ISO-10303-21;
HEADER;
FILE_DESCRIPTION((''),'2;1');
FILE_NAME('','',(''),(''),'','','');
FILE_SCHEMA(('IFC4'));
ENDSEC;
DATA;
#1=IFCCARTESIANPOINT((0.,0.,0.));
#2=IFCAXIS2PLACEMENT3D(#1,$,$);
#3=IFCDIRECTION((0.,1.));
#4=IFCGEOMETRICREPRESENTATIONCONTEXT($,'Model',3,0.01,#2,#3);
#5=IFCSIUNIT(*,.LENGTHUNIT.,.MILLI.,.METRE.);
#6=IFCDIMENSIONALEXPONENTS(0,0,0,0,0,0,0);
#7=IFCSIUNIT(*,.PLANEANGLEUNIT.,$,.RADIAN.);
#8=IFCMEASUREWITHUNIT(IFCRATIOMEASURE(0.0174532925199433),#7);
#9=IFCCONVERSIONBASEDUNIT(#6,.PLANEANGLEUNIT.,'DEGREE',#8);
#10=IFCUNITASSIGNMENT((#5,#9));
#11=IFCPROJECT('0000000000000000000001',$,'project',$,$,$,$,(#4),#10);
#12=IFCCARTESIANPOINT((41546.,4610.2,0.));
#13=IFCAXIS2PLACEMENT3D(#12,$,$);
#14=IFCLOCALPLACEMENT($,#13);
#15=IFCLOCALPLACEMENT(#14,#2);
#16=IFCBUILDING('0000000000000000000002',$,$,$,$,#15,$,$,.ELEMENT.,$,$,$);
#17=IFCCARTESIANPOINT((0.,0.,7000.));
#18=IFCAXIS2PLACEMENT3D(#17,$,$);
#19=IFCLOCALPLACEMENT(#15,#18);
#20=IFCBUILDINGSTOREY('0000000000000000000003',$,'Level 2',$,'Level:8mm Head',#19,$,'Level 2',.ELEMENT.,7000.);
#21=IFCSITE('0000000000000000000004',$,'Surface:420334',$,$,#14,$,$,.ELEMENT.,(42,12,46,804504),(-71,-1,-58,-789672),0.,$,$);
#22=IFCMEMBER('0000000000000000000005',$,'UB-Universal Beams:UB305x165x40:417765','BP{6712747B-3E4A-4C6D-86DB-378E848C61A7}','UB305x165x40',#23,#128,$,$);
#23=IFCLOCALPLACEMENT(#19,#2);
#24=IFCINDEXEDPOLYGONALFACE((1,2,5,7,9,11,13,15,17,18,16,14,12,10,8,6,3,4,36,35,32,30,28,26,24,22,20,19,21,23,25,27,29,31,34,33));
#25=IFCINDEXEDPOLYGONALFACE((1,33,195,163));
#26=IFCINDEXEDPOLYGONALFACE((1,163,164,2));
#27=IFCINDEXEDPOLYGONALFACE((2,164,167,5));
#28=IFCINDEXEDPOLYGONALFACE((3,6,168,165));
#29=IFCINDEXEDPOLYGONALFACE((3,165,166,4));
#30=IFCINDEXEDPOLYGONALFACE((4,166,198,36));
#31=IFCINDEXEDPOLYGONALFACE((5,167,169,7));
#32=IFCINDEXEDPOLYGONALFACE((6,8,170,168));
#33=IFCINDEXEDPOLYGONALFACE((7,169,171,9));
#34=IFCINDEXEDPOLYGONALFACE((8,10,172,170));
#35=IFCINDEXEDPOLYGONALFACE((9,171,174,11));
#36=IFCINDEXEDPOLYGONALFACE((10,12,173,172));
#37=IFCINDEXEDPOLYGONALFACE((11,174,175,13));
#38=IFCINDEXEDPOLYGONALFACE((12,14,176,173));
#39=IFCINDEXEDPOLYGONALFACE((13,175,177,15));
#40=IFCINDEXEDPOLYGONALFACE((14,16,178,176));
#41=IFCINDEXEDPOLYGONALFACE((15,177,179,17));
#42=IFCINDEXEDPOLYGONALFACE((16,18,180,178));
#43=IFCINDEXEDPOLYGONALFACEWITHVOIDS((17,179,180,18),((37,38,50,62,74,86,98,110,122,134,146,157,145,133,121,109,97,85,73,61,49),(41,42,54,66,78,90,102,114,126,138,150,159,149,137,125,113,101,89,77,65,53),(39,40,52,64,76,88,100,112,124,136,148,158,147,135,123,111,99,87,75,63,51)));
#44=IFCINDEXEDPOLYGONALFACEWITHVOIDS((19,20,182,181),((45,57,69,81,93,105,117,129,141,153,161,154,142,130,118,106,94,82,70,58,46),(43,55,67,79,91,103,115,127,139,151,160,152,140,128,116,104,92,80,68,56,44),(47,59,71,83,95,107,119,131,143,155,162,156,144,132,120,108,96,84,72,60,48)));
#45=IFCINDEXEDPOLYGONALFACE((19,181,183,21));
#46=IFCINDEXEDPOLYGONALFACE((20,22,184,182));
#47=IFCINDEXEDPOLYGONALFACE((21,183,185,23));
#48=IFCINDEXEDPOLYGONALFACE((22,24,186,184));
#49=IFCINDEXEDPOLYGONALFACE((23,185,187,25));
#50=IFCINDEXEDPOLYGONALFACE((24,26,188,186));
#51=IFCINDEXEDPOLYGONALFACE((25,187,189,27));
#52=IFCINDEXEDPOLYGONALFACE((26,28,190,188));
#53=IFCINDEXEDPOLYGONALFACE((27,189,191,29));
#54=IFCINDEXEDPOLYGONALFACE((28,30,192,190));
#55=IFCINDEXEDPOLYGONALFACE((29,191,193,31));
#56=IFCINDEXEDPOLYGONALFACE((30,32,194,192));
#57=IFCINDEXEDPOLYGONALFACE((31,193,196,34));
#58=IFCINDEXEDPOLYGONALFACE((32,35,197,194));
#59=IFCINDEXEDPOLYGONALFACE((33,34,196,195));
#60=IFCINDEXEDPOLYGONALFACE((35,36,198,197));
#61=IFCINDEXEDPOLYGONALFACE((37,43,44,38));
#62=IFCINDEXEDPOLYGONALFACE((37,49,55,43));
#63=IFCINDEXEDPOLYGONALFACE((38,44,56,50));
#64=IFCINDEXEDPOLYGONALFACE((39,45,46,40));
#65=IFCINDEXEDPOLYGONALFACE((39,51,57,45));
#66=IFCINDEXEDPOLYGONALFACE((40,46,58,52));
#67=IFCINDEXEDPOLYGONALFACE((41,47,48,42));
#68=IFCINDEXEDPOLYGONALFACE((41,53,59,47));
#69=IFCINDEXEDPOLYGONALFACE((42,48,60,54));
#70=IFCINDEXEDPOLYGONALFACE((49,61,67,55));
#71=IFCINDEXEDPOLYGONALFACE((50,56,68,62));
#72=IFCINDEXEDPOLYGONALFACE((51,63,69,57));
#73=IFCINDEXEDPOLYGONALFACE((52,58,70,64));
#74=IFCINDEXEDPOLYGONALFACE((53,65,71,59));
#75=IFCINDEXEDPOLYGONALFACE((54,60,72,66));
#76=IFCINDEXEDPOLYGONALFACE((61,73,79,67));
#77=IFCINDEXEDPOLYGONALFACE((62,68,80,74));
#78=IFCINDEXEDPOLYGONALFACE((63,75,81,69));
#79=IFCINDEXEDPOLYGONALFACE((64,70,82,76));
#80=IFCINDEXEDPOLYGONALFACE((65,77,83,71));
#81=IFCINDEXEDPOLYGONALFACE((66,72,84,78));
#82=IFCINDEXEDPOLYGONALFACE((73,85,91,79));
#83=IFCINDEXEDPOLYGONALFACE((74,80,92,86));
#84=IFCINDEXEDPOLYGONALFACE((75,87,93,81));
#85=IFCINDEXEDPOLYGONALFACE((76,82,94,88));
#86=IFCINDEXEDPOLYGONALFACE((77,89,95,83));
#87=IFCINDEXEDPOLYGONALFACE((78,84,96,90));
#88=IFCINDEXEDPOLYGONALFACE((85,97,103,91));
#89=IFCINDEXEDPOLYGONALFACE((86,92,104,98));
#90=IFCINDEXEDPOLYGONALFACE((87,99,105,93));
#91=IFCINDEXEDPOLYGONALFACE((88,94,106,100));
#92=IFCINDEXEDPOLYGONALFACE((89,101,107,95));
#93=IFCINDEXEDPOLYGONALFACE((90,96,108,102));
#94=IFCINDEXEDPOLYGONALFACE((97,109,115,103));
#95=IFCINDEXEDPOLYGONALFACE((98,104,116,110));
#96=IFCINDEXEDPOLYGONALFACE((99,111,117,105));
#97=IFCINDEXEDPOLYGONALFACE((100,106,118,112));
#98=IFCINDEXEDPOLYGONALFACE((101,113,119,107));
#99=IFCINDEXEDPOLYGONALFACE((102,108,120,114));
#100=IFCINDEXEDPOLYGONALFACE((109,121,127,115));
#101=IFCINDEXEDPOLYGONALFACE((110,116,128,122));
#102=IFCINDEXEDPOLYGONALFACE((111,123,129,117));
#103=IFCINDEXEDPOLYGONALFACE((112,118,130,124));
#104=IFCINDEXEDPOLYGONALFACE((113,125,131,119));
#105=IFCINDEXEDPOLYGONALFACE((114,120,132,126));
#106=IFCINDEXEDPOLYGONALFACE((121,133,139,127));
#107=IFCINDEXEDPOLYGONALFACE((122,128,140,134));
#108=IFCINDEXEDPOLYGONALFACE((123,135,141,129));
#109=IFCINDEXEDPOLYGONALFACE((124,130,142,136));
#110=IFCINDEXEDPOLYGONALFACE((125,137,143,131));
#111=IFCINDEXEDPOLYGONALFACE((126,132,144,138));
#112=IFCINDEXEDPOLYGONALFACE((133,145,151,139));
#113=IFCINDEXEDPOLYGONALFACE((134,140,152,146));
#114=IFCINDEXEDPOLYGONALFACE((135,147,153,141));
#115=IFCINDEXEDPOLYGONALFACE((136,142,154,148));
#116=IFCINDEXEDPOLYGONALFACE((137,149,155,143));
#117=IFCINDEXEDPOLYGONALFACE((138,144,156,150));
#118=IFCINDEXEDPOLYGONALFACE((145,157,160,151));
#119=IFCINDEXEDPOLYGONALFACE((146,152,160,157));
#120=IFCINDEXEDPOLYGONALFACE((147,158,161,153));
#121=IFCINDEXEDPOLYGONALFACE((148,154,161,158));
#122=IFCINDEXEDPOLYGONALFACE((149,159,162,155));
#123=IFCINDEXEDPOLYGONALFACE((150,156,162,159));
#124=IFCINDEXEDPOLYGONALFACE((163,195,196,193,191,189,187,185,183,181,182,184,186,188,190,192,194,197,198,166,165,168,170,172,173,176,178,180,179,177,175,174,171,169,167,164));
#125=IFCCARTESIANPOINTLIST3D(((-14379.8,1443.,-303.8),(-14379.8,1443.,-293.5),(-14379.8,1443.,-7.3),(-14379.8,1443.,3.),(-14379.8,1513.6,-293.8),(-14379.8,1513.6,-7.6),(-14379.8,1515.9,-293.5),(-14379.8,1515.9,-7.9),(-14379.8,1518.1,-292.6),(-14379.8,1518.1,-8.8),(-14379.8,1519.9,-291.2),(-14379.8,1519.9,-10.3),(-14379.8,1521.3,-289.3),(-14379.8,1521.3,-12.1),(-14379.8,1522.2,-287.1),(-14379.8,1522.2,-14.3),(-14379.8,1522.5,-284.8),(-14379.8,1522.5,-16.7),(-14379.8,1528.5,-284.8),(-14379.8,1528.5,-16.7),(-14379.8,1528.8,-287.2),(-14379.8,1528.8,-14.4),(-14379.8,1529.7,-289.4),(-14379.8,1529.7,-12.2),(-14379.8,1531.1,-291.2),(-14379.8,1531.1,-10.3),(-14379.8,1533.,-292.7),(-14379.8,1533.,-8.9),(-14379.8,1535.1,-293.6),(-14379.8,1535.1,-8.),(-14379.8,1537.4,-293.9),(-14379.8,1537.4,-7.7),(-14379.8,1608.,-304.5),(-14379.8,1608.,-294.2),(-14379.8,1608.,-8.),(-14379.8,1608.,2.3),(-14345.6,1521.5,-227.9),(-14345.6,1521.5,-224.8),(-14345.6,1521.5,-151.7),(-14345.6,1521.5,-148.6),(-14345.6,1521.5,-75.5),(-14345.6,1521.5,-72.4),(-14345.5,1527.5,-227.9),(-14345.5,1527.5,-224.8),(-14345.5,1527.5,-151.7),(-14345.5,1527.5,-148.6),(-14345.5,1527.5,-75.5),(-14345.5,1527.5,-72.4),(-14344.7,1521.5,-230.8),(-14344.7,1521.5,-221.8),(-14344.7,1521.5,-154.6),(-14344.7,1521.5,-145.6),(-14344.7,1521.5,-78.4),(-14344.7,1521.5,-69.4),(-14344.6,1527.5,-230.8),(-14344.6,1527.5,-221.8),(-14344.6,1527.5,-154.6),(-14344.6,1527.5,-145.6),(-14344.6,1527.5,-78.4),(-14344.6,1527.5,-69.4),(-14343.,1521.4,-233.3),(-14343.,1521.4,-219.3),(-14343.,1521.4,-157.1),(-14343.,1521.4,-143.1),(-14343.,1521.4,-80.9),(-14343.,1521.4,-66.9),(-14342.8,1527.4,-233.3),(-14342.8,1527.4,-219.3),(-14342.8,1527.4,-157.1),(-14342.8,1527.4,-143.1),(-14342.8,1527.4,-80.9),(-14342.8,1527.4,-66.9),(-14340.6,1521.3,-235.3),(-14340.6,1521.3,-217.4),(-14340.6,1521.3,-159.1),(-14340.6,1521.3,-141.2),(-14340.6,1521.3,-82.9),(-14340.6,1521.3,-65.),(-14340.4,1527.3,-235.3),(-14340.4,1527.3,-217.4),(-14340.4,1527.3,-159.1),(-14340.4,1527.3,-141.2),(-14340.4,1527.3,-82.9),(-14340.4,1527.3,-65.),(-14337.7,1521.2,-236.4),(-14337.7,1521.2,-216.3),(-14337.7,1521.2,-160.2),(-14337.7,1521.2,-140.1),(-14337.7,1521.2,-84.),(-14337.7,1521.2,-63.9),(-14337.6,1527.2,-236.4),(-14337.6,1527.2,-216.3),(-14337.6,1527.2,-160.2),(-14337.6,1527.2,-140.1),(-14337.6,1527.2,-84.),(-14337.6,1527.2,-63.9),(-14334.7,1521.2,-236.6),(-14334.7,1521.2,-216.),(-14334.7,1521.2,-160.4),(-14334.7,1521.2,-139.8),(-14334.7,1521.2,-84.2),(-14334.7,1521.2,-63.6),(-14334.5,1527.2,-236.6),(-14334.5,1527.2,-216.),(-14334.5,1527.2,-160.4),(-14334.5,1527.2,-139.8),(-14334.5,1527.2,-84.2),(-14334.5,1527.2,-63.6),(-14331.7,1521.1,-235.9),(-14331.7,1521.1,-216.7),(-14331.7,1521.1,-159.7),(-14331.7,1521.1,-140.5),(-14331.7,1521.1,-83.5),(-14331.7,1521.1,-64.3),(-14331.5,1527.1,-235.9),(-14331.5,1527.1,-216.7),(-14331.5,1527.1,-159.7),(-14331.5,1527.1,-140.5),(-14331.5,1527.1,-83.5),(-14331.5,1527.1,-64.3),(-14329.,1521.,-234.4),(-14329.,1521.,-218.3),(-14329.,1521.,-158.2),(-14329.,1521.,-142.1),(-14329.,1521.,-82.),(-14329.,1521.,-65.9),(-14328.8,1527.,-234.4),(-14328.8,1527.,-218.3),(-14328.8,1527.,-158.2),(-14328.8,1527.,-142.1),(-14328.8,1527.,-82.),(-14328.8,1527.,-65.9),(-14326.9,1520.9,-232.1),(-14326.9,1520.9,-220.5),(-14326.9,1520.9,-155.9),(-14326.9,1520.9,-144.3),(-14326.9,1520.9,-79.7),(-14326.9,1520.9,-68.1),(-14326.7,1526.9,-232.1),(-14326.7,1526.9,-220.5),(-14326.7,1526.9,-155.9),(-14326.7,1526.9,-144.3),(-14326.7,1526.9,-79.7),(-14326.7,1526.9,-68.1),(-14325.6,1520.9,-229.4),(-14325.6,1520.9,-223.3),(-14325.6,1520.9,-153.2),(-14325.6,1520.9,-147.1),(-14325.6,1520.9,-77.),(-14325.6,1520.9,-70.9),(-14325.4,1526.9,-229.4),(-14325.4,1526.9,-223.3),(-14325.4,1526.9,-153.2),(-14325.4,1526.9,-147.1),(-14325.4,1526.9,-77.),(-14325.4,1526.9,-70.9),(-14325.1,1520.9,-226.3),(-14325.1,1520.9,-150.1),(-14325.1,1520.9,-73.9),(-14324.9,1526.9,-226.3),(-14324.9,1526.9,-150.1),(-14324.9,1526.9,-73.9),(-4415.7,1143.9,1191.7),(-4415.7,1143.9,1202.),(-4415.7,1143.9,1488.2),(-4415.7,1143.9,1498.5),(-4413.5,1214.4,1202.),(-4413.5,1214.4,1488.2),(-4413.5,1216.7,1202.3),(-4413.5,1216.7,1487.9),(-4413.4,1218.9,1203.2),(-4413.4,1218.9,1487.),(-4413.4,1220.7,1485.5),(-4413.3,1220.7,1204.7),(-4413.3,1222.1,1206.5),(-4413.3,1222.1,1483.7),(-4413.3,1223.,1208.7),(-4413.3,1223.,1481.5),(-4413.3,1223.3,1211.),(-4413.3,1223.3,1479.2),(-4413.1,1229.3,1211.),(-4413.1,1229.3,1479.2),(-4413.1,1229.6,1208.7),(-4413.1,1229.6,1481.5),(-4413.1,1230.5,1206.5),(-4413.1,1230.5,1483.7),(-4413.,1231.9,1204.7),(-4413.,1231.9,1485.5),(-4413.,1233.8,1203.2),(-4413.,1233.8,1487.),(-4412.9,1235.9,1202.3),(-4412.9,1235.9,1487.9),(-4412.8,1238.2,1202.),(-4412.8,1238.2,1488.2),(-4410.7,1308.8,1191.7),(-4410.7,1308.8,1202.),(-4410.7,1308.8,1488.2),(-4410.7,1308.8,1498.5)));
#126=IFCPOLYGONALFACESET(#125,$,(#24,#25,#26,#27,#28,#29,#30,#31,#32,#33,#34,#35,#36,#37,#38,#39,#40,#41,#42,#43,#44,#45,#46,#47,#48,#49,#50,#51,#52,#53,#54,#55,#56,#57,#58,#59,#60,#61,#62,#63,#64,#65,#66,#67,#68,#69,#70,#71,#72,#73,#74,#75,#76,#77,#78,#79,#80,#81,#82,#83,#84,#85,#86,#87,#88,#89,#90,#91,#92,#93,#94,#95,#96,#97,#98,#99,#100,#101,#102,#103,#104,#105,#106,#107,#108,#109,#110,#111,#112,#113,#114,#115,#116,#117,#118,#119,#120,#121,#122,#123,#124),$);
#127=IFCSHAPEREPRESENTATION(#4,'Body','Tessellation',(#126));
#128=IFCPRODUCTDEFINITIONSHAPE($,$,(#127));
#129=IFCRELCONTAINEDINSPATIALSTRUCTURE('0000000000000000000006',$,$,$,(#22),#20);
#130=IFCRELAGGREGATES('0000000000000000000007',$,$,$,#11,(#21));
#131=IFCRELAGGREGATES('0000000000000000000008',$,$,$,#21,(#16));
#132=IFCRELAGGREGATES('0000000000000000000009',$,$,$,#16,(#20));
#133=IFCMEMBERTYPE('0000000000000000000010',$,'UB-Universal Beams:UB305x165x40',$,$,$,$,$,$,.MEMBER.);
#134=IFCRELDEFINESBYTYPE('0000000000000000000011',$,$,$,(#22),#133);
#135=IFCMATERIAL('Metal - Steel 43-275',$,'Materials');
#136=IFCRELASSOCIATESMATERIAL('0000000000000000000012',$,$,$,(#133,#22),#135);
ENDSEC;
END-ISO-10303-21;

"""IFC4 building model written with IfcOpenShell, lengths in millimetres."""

from ifc_helpers import new_model, entity, si_unit, converted_unit, direction, frame, frame_2d, origin, origin_2d, origin_2d_with_axis, place, context, project, spatial, circle, i_section, extrude, clip, halfspace, material, type_object, element, save


model = new_model("IFC4")

# Units and contexts
model_context = context("Model", 3, precision=0.01, world=origin(), true_north=direction((0.0, 1.0)))
ifc_project = project(units=[si_unit("LENGTHUNIT", "METRE", prefix="MILLI"), converted_unit("PLANEANGLEUNIT", "DEGREE", entity("IfcRatioMeasure", 0.0174532925199433), si_unit("PLANEANGLEUNIT", "RADIAN"), dimensions=[0, 0, 0, 0, 0, 0, 0])], contexts=[model_context])

# Site, building, storey
site_placement = place(None, frame((41546.0, 4610.2, 0.0)))
site = spatial("IfcSite", under=ifc_project, at=site_placement, Name="Surface:420334", CompositionType="ELEMENT", RefLatitude=(42, 12, 46, 804504), RefLongitude=(-71, -1, -58, -789672), RefElevation=0.0)
building_placement = place(site_placement, origin())
building = spatial("IfcBuilding", under=site, at=building_placement, CompositionType="ELEMENT")
storey_placement = place(building_placement, frame((0.0, 0.0, 7000.0)))
storey = spatial("IfcBuildingStorey", under=building, at=storey_placement, Name="Level 2", ObjectType="Level:8mm Head", LongName="Level 2", CompositionType="ELEMENT", Elevation=7000.0)

# Member, openings
ifc_material_1 = material(Name="Metal - Steel 43-275", Category="Materials")
member_type = type_object("IfcMemberType", Name="UB-Universal Beams:UB305x165x40", PredefinedType="MEMBER", material=ifc_material_1)
member_placement = place(storey_placement, frame((-14851.0, 1539.7, -221.5), z_axis=(-0.988488, 0.029672, -0.148359), x_axis=(-0.030004, -0.99955, 0.0)))
member = element("IfcMember", 1, at=member_placement, inside=storey, type_object=member_type, material=ifc_material_1, Name="UB-Universal Beams:UB305x165x40:417765", Description="BP{6712747B-3E4A-4C6D-86DB-378E848C61A7}", ObjectType="UB305x165x40", context=model_context, shape_type="Clipping", body=[
    clip(clip(extrude(i_section(OverallWidth=165.0, OverallDepth=303.4, WebThickness=6.0, FlangeThickness=10.2, FilletRadius=8.9, at=origin_2d()), origin(), (0.0, 0.0, -1.0), 11073.7), halfspace(frame((1093.4, -8252.9, -9321.5), z_axis=(0.0, 0.14834, 0.988936), x_axis=(1.0, 0.0, 0.0)), True)), halfspace(frame((1524.8, -6780.2, 494.2), z_axis=(-0.030004, -0.148292, -0.988488), x_axis=(-0.99955, 0.004451, 0.029672)), True)),
])
opening_1_placement = place(member_placement, frame((3.5, -6.0, -520.8), z_axis=(-1.0, 0.0, 0.0), x_axis=(0.0, -0.148359, -0.988934)))
element("IfcOpeningElement", 2, at=opening_1_placement, cuts=member, ObjectType="Opening", context=model_context, shape_type="SweptSolid", body=[
    extrude(circle(Radius=10.3, at=origin_2d_with_axis()), origin(), (0.0, 0.0, 1.0), 7.0),
])
opening_2_placement = place(member_placement, frame((3.5, -6.0, -520.8), z_axis=(-1.0, 0.0, 0.0), x_axis=(0.0, -0.148359, -0.988934)))
element("IfcOpeningElement", 3, at=opening_2_placement, cuts=member, ObjectType="Opening", context=model_context, shape_type="SweptSolid", body=[
    extrude(circle(Radius=10.3, at=frame_2d((0.0, 76.2), x_axis=(1.0, 0.0))), origin(), (0.0, 0.0, 1.0), 7.0),
])
opening_3_placement = place(member_placement, frame((3.5, -6.0, -520.8), z_axis=(-1.0, 0.0, 0.0), x_axis=(0.0, -0.148359, -0.988934)))
element("IfcOpeningElement", 4, at=opening_3_placement, cuts=member, ObjectType="Opening", context=model_context, shape_type="SweptSolid", body=[
    extrude(circle(Radius=10.3, at=frame_2d((0.0, -76.2), x_axis=(1.0, 0.0))), origin(), (0.0, 0.0, 1.0), 7.0),
])

save(model, "model.ifc")
